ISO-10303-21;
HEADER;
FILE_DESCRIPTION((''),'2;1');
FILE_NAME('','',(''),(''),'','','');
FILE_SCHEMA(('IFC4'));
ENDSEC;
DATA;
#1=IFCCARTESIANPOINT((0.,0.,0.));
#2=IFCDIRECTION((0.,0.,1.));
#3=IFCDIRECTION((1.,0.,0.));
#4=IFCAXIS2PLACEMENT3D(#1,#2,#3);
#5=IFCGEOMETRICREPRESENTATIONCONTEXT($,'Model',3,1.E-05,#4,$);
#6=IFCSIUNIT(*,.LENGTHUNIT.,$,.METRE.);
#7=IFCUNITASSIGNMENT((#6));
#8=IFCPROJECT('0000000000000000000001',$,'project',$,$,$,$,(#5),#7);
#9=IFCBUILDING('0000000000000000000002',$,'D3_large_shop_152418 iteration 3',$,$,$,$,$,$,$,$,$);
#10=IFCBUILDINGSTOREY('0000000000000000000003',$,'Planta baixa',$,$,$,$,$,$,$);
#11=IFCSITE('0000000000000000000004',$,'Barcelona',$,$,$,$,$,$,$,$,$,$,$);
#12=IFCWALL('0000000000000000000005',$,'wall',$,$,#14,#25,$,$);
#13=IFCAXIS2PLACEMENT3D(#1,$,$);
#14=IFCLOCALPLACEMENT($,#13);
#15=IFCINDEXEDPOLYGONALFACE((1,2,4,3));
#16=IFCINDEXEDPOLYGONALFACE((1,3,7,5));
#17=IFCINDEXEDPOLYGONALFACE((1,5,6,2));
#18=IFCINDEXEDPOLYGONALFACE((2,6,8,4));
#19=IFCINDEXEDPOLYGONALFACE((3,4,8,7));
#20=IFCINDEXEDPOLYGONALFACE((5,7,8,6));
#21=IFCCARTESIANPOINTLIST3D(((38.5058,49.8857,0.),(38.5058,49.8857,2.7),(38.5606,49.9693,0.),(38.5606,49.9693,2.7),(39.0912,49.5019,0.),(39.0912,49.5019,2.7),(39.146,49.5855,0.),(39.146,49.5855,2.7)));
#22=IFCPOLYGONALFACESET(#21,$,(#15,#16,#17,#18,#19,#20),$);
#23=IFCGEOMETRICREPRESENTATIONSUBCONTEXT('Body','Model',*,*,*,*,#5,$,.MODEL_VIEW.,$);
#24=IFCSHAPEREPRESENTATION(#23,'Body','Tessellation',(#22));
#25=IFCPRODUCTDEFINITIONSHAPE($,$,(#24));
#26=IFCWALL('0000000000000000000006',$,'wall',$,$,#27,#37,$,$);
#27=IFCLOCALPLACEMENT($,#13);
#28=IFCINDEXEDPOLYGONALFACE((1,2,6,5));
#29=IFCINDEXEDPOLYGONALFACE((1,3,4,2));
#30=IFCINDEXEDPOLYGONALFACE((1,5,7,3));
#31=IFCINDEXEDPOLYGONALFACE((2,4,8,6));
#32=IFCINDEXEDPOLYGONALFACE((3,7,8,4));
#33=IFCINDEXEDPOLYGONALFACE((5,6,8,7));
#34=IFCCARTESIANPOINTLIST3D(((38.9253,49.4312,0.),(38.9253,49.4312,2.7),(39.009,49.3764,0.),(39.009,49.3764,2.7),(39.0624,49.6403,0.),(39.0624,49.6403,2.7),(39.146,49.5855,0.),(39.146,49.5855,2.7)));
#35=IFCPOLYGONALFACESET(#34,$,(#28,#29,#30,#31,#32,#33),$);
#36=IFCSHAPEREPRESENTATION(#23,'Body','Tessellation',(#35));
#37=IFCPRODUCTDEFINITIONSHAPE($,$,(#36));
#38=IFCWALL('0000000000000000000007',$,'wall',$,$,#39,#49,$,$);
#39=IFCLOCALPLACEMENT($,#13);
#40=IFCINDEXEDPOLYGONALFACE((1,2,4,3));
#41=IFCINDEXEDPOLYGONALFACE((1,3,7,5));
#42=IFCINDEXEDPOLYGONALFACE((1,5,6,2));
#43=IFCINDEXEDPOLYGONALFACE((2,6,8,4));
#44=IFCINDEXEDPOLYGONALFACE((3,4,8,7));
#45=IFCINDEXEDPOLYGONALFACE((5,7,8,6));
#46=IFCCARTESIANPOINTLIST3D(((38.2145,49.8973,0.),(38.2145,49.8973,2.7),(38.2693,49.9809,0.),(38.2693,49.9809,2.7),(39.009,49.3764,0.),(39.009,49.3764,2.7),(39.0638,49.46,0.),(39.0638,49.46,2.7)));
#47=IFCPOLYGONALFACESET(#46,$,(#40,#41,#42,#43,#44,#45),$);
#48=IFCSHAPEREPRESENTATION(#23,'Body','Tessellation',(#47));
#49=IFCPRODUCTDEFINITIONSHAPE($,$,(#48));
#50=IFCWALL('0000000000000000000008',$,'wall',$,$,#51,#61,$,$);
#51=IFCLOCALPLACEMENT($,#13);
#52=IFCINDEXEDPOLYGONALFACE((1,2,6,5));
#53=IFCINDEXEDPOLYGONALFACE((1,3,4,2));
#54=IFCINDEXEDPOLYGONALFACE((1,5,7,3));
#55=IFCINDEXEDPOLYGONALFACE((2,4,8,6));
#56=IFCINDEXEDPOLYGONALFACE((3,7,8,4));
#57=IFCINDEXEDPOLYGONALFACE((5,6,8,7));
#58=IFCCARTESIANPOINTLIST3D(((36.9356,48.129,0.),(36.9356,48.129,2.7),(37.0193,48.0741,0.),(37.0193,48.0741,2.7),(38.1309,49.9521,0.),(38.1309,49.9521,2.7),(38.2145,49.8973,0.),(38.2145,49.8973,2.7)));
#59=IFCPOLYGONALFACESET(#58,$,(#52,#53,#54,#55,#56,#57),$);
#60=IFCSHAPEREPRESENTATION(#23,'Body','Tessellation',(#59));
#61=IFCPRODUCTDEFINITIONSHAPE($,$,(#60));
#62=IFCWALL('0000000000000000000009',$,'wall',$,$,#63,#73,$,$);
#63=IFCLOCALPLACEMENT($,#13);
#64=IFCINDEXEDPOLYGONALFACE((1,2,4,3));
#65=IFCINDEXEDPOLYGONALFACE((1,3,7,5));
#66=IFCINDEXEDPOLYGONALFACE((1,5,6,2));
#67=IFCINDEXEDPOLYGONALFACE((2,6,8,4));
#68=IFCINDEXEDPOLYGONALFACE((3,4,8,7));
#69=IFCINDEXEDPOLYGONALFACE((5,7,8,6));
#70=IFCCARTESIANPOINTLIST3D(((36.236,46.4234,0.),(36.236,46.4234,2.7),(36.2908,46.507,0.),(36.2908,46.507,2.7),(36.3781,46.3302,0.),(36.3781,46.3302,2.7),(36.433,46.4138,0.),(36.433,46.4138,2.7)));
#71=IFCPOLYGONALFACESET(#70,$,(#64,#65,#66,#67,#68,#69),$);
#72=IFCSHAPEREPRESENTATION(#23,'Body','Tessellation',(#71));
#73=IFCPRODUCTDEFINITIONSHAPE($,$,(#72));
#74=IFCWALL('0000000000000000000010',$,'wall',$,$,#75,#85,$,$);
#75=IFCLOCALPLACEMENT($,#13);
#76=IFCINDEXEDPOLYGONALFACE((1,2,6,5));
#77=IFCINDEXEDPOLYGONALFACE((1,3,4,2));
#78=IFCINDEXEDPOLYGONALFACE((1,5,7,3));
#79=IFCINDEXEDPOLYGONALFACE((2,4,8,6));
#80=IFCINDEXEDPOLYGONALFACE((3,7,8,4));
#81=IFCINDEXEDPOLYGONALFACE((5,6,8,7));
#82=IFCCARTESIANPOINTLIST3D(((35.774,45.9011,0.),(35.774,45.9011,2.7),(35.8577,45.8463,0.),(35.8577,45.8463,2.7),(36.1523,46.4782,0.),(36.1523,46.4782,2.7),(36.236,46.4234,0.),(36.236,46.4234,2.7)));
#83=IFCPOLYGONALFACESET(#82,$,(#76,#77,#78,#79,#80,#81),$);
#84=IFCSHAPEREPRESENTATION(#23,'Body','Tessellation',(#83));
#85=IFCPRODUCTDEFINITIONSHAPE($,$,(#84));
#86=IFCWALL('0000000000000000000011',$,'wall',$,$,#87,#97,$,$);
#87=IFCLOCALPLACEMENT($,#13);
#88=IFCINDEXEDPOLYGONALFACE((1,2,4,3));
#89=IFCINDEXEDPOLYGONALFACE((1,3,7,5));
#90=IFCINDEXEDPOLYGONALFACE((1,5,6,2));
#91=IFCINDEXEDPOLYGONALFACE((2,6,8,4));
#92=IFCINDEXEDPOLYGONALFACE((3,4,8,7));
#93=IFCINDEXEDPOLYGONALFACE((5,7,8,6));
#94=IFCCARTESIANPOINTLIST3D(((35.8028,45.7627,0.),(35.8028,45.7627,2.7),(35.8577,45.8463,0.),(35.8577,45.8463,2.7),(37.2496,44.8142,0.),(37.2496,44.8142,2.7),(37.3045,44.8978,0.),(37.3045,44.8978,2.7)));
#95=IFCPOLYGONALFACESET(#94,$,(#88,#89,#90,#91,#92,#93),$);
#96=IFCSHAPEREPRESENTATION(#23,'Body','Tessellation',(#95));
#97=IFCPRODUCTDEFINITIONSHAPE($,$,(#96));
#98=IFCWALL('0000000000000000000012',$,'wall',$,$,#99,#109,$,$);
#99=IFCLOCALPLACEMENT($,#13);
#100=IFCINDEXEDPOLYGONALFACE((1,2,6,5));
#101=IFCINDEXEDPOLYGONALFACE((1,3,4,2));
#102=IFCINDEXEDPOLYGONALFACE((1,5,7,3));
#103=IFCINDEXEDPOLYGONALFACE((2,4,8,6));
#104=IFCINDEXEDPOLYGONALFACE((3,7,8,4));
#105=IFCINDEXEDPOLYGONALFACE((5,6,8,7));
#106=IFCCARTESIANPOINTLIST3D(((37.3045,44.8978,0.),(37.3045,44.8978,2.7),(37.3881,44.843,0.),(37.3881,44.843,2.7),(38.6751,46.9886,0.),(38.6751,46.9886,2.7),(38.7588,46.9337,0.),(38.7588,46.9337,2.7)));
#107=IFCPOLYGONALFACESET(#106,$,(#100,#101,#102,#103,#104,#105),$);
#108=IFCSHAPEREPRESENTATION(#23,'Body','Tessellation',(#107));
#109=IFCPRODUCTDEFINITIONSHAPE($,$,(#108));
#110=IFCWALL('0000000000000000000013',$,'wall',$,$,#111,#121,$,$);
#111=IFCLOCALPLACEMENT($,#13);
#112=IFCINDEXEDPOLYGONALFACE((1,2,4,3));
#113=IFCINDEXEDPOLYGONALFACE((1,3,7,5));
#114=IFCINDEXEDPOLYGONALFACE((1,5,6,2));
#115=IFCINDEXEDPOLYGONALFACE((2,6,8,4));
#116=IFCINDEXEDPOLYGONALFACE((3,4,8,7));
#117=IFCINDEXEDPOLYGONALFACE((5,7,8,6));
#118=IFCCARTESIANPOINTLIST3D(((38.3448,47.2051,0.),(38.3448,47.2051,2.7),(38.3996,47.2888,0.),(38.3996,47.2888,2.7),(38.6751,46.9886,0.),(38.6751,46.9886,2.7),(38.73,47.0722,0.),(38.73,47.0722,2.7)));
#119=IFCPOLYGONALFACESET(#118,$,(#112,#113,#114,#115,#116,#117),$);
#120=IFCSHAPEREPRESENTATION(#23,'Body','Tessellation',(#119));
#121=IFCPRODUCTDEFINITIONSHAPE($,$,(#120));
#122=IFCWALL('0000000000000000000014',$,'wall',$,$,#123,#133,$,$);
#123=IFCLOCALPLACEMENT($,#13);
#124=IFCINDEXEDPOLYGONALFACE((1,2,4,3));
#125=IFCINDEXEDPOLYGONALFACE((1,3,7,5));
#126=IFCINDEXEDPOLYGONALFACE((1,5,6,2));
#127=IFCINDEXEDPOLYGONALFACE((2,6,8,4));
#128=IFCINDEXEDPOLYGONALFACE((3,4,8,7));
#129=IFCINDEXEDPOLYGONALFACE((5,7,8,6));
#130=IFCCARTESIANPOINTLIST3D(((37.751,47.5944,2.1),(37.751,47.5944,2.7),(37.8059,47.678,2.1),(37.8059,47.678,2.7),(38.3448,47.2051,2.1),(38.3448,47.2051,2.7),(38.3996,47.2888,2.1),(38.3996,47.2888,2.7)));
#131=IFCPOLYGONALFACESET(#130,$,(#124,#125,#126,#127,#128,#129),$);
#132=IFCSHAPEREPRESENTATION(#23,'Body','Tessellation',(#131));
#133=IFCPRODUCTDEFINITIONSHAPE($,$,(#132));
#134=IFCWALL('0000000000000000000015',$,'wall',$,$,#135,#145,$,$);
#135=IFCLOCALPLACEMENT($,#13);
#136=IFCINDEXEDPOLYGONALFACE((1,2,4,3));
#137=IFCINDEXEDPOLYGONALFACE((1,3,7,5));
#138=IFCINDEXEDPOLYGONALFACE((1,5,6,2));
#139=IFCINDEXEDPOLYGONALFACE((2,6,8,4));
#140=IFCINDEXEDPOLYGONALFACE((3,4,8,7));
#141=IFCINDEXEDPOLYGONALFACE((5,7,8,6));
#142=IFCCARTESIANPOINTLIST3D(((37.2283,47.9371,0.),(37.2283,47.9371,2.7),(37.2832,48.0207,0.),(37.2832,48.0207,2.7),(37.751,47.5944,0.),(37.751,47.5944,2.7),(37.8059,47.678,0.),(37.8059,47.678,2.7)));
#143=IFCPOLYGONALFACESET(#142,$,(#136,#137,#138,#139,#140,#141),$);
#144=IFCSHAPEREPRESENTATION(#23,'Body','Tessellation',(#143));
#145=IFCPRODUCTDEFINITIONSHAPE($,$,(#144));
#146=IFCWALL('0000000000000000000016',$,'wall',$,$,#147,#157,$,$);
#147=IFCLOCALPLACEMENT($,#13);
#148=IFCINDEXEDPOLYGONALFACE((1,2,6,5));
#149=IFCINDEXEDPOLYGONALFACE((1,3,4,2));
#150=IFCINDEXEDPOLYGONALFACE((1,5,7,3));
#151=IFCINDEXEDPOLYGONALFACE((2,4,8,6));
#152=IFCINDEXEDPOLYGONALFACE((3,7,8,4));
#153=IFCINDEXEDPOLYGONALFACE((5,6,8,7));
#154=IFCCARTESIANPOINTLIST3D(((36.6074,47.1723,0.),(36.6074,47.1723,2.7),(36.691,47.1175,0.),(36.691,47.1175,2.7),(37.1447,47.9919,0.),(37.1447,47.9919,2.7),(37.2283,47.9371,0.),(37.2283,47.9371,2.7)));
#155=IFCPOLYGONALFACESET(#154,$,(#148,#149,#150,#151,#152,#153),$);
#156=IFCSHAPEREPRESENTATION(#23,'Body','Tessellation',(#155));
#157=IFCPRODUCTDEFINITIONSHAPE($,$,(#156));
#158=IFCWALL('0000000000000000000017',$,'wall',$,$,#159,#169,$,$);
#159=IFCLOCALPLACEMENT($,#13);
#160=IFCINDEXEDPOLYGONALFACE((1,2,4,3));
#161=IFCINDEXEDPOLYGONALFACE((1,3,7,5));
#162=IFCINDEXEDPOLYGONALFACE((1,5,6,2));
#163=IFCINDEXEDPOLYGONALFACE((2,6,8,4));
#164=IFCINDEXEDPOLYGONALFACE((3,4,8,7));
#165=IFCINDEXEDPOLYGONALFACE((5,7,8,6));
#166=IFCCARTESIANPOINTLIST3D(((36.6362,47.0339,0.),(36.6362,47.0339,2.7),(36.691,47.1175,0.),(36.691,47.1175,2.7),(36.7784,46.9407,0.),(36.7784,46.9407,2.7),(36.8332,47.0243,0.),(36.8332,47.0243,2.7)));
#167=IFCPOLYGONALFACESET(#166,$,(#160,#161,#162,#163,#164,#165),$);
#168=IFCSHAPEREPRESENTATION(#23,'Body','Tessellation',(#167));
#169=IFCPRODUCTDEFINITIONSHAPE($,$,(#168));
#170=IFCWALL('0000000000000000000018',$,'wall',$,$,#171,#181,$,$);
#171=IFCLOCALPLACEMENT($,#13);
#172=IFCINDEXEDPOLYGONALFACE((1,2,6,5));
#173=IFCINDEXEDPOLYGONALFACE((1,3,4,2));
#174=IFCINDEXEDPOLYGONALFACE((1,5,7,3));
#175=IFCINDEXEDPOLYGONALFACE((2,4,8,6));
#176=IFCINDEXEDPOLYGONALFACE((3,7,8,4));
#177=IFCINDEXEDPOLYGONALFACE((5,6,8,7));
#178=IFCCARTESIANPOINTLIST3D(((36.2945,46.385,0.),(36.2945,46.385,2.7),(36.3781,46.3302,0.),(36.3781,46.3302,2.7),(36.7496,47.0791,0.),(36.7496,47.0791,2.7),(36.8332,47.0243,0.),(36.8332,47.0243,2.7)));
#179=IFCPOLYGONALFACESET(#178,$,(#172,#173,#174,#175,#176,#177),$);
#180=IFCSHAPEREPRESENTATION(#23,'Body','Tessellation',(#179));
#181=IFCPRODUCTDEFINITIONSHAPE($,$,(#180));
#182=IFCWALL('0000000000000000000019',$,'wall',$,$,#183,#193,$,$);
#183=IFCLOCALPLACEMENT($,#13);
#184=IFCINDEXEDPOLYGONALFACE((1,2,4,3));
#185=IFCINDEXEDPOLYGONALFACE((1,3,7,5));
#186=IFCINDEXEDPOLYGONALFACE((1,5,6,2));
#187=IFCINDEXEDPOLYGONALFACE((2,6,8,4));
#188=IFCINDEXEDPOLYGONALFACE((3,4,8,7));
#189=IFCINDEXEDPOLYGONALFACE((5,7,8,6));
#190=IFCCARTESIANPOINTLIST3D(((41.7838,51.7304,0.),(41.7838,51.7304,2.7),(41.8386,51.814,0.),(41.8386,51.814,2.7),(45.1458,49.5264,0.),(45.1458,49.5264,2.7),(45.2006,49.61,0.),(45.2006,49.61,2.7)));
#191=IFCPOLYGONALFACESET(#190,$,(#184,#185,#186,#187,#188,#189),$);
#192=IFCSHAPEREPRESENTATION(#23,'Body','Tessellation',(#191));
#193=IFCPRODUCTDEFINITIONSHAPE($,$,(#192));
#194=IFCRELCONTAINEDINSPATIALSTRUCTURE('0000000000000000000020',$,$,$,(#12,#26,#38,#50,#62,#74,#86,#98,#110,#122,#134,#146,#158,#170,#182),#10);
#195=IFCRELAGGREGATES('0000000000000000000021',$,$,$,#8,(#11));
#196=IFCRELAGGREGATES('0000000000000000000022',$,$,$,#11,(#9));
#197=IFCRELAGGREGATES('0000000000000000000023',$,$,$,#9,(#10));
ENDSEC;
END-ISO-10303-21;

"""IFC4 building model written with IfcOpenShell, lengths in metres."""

from ifc_helpers import new_model, si_unit, frame, origin, origin_with_axes, place, context, subcontext, project, spatial, polyline, outline, extrude, element, save


model = new_model("IFC4")

# Units and contexts
model_context = context("Model", 3, precision=1e-05, world=origin_with_axes())
body_context = subcontext(model_context, "Body", "Model", "MODEL_VIEW")
ifc_project = project(units=[si_unit("LENGTHUNIT", "METRE")], contexts=[model_context])

# Site, building, storey
site = spatial("IfcSite", under=ifc_project, Name="Barcelona")
building = spatial("IfcBuilding", under=site, Name="D3_large_shop_152418 iteration 3")
storey = spatial("IfcBuildingStorey", under=building, Name="Planta baixa")

# Walls
wall_1_placement = place(None, origin_with_axes())
element("IfcWall", 1, at=wall_1_placement, inside=storey, Name="wall", context=body_context, shape_type="SweptSolid", body=[
    extrude(outline(polyline([(38.5606, 49.9693), (39.146, 49.5855), (39.0912, 49.5019), (38.5058, 49.8857), (38.5606, 49.9693)])), origin(), (0.0, 0.0, 1.0), 2.7),
])
wall_2_placement = place(None, origin_with_axes())
element("IfcWall", 2, at=wall_2_placement, inside=storey, Name="wall", context=body_context, shape_type="SweptSolid", body=[
    extrude(outline(polyline([(39.146, 49.5855), (39.009, 49.3764), (38.9253, 49.4312), (39.0624, 49.6403), (39.146, 49.5855)])), origin(), (0.0, 0.0, 1.0), 2.7),
])
wall_3_placement = place(None, origin_with_axes())
element("IfcWall", 3, at=wall_3_placement, inside=storey, Name="wall", context=body_context, shape_type="SweptSolid", body=[
    extrude(outline(polyline([(39.009, 49.3764), (38.2145, 49.8973), (38.2693, 49.9809), (39.0638, 49.46), (39.009, 49.3764)])), origin(), (0.0, 0.0, 1.0), 2.7),
])
wall_4_placement = place(None, origin_with_axes())
element("IfcWall", 4, at=wall_4_placement, inside=storey, Name="wall", context=body_context, shape_type="SweptSolid", body=[
    extrude(outline(polyline([(38.2145, 49.8973), (37.0193, 48.0741), (36.9356, 48.129), (38.1309, 49.9521), (38.2145, 49.8973)])), origin(), (0.0, 0.0, 1.0), 2.7),
])
wall_5_placement = place(None, origin_with_axes())
element("IfcWall", 5, at=wall_5_placement, inside=storey, Name="wall", context=body_context, shape_type="SweptSolid", body=[
    extrude(outline(polyline([(36.3781, 46.3302), (36.236, 46.4234), (36.2908, 46.507), (36.433, 46.4138), (36.3781, 46.3302)])), origin(), (0.0, 0.0, 1.0), 2.7),
])
wall_6_placement = place(None, origin_with_axes())
element("IfcWall", 6, at=wall_6_placement, inside=storey, Name="wall", context=body_context, shape_type="SweptSolid", body=[
    extrude(outline(polyline([(36.236, 46.4234), (35.8577, 45.8463), (35.774, 45.9011), (36.1523, 46.4782), (36.236, 46.4234)])), origin(), (0.0, 0.0, 1.0), 2.7),
])
wall_7_placement = place(None, origin_with_axes())
element("IfcWall", 7, at=wall_7_placement, inside=storey, Name="wall", context=body_context, shape_type="SweptSolid", body=[
    extrude(outline(polyline([(35.8577, 45.8463), (37.3045, 44.8978), (37.2496, 44.8142), (35.8028, 45.7627), (35.8577, 45.8463)])), origin(), (0.0, 0.0, 1.0), 2.7),
])
wall_8_placement = place(None, origin_with_axes())
element("IfcWall", 8, at=wall_8_placement, inside=storey, Name="wall", context=body_context, shape_type="SweptSolid", body=[
    extrude(outline(polyline([(37.3045, 44.8978), (38.6751, 46.9886), (38.7588, 46.9337), (37.3881, 44.843), (37.3045, 44.8978)])), origin(), (0.0, 0.0, 1.0), 2.7),
])
wall_9_placement = place(None, origin_with_axes())
element("IfcWall", 9, at=wall_9_placement, inside=storey, Name="wall", context=body_context, shape_type="SweptSolid", body=[
    extrude(outline(polyline([(38.6751, 46.9886), (38.3448, 47.2051), (38.3996, 47.2888), (38.73, 47.0722), (38.6751, 46.9886)])), origin(), (0.0, 0.0, 1.0), 2.7),
])
wall_10_placement = place(None, origin_with_axes())
element("IfcWall", 10, at=wall_10_placement, inside=storey, Name="wall", context=body_context, shape_type="SweptSolid", body=[
    extrude(outline(polyline([(38.3448, 47.2051), (37.751, 47.5944), (37.8059, 47.678), (38.3996, 47.2888), (38.3448, 47.2051)])), frame((0.0, 0.0, 2.1)), (0.0, 0.0, 1.0), 0.6),
])
wall_11_placement = place(None, origin_with_axes())
element("IfcWall", 11, at=wall_11_placement, inside=storey, Name="wall", context=body_context, shape_type="SweptSolid", body=[
    extrude(outline(polyline([(37.751, 47.5944), (37.2283, 47.9371), (37.2832, 48.0207), (37.8059, 47.678), (37.751, 47.5944)])), origin(), (0.0, 0.0, 1.0), 2.7),
])
wall_12_placement = place(None, origin_with_axes())
element("IfcWall", 12, at=wall_12_placement, inside=storey, Name="wall", context=body_context, shape_type="SweptSolid", body=[
    extrude(outline(polyline([(37.2283, 47.9371), (36.691, 47.1175), (36.6074, 47.1723), (37.1447, 47.9919), (37.2283, 47.9371)])), origin(), (0.0, 0.0, 1.0), 2.7),
])
wall_13_placement = place(None, origin_with_axes())
element("IfcWall", 13, at=wall_13_placement, inside=storey, Name="wall", context=body_context, shape_type="SweptSolid", body=[
    extrude(outline(polyline([(36.691, 47.1175), (36.8332, 47.0243), (36.7784, 46.9407), (36.6362, 47.0339), (36.691, 47.1175)])), origin(), (0.0, 0.0, 1.0), 2.7),
])
wall_14_placement = place(None, origin_with_axes())
element("IfcWall", 14, at=wall_14_placement, inside=storey, Name="wall", context=body_context, shape_type="SweptSolid", body=[
    extrude(outline(polyline([(36.8332, 47.0243), (36.3781, 46.3302), (36.2945, 46.385), (36.7496, 47.0791), (36.8332, 47.0243)])), origin(), (0.0, 0.0, 1.0), 2.7),
])
wall_15_placement = place(None, origin_with_axes())
element("IfcWall", 15, at=wall_15_placement, inside=storey, Name="wall", context=body_context, shape_type="SweptSolid", body=[
    extrude(outline(polyline([(45.1458, 49.5264), (41.7838, 51.7304), (41.8386, 51.814), (45.2006, 49.61), (45.1458, 49.5264)])), origin(), (0.0, 0.0, 1.0), 2.7),
])

save(model, "model.ifc")
